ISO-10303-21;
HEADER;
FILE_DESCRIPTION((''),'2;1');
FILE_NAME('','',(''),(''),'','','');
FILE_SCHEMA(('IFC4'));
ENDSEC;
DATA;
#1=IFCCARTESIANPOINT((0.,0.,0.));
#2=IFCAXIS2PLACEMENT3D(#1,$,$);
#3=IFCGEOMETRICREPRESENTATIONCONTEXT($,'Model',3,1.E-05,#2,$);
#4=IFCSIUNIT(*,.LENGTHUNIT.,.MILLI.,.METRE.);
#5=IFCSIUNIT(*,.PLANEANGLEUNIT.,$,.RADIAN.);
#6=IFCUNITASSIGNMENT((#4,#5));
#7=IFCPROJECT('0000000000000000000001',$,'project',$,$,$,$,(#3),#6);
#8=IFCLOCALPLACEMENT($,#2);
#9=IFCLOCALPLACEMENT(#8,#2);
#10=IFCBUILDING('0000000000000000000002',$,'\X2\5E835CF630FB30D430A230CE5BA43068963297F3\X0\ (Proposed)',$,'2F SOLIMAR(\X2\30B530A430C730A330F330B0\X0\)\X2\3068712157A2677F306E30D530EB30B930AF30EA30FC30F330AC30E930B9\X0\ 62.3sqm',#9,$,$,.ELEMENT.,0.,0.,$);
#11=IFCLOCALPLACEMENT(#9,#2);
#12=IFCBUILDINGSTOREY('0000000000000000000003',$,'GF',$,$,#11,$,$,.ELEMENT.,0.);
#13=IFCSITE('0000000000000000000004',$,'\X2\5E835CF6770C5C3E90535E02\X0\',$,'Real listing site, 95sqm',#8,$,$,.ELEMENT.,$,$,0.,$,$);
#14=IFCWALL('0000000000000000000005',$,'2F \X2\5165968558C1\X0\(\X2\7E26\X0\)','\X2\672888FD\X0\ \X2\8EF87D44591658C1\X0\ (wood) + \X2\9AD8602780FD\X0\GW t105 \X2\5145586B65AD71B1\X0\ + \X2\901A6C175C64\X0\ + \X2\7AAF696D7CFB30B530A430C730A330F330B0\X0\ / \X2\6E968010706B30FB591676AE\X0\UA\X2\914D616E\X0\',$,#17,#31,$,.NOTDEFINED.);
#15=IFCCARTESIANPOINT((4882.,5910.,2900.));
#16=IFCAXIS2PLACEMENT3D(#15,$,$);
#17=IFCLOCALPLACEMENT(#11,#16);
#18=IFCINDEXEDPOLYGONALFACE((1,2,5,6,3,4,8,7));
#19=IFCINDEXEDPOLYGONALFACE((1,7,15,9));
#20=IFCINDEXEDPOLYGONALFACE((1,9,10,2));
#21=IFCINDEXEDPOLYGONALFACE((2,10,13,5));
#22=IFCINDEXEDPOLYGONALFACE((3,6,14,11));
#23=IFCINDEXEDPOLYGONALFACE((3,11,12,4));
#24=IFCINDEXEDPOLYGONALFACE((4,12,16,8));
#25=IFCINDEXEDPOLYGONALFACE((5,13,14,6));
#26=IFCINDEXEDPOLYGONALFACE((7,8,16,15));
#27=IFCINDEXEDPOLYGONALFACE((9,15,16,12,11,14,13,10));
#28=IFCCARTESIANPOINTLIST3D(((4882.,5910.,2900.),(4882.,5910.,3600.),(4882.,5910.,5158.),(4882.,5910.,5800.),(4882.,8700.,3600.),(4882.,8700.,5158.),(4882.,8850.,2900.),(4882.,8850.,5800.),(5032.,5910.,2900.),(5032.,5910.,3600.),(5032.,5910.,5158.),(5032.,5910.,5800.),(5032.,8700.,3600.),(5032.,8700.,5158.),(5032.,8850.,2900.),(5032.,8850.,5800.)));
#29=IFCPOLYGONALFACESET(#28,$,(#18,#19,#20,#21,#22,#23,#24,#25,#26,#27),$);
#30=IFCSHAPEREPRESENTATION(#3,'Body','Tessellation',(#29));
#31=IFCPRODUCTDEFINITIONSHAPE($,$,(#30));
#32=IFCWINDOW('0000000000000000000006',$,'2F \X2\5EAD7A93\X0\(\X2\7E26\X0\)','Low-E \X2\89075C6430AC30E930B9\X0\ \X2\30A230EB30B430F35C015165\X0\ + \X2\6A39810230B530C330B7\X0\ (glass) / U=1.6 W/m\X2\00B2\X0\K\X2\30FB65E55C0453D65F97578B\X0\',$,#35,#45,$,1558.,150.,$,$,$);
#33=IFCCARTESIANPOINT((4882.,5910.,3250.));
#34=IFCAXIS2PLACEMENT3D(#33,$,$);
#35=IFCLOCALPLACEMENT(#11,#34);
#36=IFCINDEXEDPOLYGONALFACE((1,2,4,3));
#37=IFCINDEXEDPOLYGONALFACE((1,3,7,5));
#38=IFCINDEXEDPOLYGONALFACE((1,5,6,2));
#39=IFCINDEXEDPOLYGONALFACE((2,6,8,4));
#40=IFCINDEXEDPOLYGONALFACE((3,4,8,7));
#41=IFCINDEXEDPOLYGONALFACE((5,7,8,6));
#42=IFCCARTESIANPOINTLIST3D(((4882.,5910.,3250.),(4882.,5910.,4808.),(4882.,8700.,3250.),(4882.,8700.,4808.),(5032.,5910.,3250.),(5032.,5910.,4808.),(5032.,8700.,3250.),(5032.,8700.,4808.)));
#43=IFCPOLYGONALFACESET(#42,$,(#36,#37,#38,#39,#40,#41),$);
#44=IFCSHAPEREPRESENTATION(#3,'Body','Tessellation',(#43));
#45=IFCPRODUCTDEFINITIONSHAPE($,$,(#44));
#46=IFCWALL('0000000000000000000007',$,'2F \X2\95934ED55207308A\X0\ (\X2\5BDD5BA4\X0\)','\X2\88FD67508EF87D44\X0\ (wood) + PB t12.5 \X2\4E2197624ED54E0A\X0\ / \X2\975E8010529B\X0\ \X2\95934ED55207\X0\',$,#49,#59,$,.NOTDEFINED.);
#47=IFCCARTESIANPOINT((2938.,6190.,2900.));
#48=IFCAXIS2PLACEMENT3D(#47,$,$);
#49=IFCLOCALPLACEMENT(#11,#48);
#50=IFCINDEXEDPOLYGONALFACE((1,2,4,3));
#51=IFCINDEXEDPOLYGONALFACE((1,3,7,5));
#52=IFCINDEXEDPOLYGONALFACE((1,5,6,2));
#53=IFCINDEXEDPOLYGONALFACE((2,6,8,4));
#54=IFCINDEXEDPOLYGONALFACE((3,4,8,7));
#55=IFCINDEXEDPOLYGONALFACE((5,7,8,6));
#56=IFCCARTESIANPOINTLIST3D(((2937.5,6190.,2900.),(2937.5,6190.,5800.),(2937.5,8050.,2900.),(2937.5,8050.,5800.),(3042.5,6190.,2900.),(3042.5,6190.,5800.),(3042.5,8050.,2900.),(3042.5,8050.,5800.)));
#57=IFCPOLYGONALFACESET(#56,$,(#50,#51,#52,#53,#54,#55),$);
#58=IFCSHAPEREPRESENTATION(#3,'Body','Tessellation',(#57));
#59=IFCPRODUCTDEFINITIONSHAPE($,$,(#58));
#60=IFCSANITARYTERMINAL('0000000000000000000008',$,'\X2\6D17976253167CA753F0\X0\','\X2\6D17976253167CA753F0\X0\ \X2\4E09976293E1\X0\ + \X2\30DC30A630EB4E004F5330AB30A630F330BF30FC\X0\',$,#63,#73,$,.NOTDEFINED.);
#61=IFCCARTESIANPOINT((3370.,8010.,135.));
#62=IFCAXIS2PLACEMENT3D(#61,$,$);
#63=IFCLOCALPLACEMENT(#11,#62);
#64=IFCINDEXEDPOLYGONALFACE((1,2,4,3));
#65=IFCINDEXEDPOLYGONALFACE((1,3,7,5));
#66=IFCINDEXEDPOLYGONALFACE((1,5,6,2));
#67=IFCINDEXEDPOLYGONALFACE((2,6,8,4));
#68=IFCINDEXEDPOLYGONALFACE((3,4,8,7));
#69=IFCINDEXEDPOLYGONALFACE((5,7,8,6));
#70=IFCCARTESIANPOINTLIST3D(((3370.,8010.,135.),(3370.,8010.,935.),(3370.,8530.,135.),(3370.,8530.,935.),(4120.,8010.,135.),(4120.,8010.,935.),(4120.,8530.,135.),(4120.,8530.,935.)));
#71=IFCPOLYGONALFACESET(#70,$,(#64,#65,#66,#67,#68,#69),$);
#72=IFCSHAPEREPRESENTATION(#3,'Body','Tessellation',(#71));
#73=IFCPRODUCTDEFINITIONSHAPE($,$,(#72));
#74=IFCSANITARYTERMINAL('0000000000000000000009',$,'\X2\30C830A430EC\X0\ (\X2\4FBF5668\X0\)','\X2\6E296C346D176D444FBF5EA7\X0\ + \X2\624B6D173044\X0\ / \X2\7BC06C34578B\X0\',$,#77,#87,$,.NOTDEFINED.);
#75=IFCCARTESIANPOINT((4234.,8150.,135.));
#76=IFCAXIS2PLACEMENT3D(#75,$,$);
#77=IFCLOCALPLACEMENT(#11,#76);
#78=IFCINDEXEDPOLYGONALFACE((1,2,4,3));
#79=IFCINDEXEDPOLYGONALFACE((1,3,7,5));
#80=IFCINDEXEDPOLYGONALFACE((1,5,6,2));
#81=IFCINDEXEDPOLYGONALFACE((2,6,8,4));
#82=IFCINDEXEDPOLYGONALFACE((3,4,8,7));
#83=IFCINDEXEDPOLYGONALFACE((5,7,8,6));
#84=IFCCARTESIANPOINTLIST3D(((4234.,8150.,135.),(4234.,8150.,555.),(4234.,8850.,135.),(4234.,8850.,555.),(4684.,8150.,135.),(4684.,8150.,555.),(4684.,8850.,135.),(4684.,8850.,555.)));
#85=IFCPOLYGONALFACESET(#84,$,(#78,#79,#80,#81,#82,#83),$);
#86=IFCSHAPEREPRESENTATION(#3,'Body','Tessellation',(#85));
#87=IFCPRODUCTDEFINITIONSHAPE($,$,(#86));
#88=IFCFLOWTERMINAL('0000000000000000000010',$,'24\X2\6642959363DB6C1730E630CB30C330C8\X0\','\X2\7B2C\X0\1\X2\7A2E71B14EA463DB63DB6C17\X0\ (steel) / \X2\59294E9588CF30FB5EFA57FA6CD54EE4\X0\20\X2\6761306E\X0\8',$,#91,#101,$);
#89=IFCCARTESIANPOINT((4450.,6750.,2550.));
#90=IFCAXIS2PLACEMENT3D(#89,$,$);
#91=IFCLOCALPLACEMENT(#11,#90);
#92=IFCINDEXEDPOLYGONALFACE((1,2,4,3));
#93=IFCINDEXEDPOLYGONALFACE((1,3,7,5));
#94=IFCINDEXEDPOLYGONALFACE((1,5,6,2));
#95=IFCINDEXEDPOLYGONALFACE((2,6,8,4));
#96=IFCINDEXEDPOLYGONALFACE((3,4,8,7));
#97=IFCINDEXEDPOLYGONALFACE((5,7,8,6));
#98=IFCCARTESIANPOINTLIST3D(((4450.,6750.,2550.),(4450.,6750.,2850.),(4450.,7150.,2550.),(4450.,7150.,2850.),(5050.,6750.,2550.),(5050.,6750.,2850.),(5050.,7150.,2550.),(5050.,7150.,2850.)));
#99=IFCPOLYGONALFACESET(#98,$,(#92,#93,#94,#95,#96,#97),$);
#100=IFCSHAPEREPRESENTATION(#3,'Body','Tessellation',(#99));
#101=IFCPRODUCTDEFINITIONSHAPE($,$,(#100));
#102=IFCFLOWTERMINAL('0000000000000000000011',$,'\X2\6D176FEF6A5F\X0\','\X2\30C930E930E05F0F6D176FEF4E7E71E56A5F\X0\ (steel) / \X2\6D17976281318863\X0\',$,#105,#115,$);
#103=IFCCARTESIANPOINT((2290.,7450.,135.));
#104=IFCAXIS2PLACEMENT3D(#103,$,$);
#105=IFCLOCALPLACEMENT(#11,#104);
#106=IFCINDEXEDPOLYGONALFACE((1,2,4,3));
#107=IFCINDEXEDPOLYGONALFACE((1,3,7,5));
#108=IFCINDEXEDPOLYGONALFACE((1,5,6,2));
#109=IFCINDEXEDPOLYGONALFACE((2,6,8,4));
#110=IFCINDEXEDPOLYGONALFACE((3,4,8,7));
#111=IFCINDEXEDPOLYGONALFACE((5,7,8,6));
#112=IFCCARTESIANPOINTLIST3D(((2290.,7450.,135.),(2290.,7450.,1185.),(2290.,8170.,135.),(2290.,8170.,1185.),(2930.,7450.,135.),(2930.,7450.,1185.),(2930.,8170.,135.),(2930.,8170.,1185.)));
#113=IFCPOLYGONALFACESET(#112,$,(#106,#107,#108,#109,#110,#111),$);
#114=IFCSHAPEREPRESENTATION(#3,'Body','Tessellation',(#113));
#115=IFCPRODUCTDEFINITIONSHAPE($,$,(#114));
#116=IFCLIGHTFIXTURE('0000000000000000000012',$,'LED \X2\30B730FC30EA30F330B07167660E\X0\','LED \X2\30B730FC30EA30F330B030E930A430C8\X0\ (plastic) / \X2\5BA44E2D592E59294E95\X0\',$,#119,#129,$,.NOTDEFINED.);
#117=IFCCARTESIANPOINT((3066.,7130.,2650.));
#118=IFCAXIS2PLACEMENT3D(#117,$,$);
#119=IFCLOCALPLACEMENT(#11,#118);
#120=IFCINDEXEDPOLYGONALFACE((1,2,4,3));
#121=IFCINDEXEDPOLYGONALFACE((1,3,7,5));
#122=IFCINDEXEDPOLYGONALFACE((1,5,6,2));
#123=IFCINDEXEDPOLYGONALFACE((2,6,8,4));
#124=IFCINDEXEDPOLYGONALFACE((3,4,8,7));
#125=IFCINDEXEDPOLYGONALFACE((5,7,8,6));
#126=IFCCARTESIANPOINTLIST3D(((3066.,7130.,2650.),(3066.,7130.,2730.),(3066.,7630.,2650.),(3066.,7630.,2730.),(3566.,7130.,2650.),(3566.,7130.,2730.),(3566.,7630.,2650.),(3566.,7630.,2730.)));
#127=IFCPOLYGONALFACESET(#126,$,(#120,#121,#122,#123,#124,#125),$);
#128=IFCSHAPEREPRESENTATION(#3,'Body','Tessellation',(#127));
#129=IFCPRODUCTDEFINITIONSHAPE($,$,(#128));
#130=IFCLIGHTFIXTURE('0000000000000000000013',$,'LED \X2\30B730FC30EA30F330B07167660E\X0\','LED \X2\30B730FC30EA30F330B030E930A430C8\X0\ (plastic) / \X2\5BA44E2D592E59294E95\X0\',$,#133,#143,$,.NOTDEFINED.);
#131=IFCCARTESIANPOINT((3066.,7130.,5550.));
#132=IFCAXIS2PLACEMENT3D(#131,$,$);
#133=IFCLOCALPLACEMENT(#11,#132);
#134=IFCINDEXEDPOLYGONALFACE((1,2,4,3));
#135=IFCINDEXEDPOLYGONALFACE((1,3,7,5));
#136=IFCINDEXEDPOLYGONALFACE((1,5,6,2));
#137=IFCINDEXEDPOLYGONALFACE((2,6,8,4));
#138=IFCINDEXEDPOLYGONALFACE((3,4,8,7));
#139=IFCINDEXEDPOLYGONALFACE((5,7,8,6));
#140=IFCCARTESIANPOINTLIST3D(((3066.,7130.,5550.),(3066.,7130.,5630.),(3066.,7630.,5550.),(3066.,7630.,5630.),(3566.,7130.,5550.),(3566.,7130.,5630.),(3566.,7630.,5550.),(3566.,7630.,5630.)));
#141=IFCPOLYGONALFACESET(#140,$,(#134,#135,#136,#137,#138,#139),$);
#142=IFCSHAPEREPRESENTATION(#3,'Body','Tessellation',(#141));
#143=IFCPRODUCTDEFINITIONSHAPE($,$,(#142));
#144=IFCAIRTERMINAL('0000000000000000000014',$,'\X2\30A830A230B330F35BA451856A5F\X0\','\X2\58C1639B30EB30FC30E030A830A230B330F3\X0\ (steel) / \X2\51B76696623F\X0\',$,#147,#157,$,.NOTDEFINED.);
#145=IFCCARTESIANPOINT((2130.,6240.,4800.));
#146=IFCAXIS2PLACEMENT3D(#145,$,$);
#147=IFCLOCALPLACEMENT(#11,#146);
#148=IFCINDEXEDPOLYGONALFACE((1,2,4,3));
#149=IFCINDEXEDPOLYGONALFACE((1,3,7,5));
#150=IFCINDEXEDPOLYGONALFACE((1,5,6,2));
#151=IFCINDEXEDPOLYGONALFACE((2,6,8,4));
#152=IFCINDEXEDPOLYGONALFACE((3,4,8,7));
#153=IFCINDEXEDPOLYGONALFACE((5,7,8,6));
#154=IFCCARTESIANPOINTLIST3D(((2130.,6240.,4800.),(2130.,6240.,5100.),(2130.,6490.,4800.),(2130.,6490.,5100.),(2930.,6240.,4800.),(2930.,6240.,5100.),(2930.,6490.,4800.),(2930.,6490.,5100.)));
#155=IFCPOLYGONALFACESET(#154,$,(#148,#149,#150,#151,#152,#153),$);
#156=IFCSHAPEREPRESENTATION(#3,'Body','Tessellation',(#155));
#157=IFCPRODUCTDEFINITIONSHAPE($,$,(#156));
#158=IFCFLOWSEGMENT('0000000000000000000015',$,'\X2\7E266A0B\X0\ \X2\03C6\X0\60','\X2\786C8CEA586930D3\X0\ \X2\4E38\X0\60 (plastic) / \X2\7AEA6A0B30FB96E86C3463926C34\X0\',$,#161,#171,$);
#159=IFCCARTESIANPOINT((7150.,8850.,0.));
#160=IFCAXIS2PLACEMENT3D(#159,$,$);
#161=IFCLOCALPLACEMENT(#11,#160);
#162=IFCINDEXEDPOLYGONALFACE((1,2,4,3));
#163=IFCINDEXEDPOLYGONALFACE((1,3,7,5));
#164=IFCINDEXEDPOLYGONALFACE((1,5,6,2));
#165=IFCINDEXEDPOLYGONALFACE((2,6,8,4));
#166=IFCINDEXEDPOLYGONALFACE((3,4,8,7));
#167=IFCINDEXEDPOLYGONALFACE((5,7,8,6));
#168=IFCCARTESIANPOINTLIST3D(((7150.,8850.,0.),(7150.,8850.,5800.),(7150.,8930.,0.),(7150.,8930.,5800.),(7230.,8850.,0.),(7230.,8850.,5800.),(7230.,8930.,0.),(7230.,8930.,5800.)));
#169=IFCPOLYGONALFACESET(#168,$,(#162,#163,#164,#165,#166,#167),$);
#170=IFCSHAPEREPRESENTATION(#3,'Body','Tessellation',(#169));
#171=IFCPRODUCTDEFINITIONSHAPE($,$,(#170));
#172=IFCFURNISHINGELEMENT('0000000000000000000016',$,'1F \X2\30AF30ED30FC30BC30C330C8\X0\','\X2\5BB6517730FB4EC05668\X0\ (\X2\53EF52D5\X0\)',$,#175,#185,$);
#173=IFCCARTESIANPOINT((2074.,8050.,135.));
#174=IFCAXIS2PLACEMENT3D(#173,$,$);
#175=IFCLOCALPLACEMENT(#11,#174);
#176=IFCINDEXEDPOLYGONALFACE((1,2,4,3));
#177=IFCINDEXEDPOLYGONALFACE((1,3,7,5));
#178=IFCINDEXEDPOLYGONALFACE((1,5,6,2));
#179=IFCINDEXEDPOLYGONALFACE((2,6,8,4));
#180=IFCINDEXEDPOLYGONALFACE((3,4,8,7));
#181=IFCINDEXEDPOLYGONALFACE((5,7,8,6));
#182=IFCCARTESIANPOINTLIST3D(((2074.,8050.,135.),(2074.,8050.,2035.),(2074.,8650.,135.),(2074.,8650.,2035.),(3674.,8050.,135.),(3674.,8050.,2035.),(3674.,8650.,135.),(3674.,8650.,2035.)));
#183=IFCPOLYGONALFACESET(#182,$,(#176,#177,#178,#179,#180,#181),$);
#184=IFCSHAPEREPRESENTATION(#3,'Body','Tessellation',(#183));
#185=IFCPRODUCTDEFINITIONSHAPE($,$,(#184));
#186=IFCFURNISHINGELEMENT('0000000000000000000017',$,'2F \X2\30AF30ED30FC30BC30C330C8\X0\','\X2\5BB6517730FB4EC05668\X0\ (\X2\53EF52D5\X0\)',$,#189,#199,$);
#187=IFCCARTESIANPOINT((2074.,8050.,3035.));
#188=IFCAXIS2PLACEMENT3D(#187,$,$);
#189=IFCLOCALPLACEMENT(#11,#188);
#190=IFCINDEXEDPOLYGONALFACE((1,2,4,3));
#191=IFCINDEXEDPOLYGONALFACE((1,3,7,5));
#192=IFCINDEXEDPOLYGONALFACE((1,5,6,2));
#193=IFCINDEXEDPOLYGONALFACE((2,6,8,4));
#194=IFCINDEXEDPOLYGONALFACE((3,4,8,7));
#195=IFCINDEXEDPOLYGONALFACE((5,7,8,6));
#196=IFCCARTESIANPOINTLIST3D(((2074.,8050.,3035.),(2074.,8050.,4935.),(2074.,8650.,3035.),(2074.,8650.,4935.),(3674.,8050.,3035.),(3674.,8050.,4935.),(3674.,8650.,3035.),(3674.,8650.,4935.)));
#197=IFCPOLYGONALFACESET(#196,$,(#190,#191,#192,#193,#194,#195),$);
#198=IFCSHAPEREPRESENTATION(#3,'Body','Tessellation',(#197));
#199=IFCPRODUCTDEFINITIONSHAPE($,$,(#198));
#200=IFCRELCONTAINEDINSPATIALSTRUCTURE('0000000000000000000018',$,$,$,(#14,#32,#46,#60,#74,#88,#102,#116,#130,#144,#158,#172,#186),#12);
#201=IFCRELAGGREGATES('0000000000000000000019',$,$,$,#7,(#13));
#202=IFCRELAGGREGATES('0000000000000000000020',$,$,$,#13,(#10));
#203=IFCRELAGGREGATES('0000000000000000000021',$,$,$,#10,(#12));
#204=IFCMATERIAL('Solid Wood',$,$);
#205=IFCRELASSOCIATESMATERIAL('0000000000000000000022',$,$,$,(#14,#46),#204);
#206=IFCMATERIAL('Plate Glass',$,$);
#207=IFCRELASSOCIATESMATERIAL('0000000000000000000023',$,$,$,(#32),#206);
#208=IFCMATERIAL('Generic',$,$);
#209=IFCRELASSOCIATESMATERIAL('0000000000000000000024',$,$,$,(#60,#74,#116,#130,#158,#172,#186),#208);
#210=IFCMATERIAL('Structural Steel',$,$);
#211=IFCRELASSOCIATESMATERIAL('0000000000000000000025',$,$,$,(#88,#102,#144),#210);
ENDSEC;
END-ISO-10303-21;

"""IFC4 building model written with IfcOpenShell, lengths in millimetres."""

from ifc_helpers import new_model, si_unit, frame, frame_2d, origin, place, context, project, spatial, rectangle, extrude, material, element, fill, save


model = new_model("IFC4")

# Units and contexts
model_context = context("Model", 3, precision=1e-05, world=origin())
ifc_project = project(units=[si_unit("LENGTHUNIT", "METRE", prefix="MILLI"), si_unit("PLANEANGLEUNIT", "RADIAN")], contexts=[model_context])

# Site, building, storey
site_placement = place(None, origin())
site = spatial("IfcSite", under=ifc_project, at=site_placement, Name="広島県尾道市", ObjectType="Real listing site, 95sqm", CompositionType="ELEMENT", RefElevation=0.0)
building_placement = place(site_placement, origin())
building = spatial("IfcBuilding", under=site, at=building_placement, Name="広島・ピアノ室と防音 (Proposed)", ObjectType="2F SOLIMAR(サイディング)と無垢板のフルスクリーンガラス 62.3sqm", CompositionType="ELEMENT", ElevationOfRefHeight=0.0, ElevationOfTerrain=0.0)
storey_placement = place(building_placement, origin())
storey = spatial("IfcBuildingStorey", under=building, at=storey_placement, Name="GF", CompositionType="ELEMENT", Elevation=0.0)

# Shared definitions
ifc_material_1 = material(Name="Solid Wood")

# Shared definitions
ifc_material_2 = material(Name="Plate Glass")

# Wall, opening, window
wall_1_placement = place(storey_placement, frame((4882.0, 5910.0, 2900.0)))
wall_1 = element("IfcWall", 1, at=wall_1_placement, inside=storey, material=ifc_material_1, Name="2F 入隅壁(縦)", Description="木製 軸組外壁 (wood) + 高性能GW t105 充填断熱 + 通気層 + 窯業系サイディング / 準耐火・外皮UA配慮", PredefinedType="NOTDEFINED", context=model_context, shape_type="SweptSolid", body=[
    extrude(rectangle(XDim=150.0, YDim=2940.0, at=frame_2d((75.0, 1470.0))), frame((4882.0, 5910.0, 2900.0)), (0.0, 0.0, 1.0), 2900.0),
])
opening_1_placement = place(storey_placement, frame((4882.0, 5910.0, 3250.0)))
opening_1 = element("IfcOpeningElement", 2, at=opening_1_placement, cuts=wall_1, PredefinedType="NOTDEFINED", context=model_context, shape_type="SweptSolid", body=[
    extrude(rectangle(XDim=150.0, YDim=2790.0, at=frame_2d((75.0, 1395.0))), frame((4882.0, 5910.0, 3250.0)), (0.0, 0.0, 1.0), 1558.0),
])
window_1_placement = place(storey_placement, frame((4882.0, 5910.0, 3250.0)))
window_1 = element("IfcWindow", 3, at=window_1_placement, inside=storey, material=ifc_material_2, Name="2F 庭窓(縦)", Description="Low-E 複層ガラス アルゴン封入 + 樹脂サッシ (glass) / U=1.6 W/m²K・日射取得型", OverallHeight=1558.0, OverallWidth=150.0, context=model_context, shape_type="SweptSolid", body=[
    extrude(rectangle(XDim=150.0, YDim=2790.0, at=frame_2d((75.0, 1395.0))), frame((4882.0, 5910.0, 3250.0)), (0.0, 0.0, 1.0), 1558.0),
])
fill(opening_1, window_1)

# Wall
wall_2_placement = place(storey_placement, frame((2938.0, 6190.0, 2900.0)))
element("IfcWall", 4, at=wall_2_placement, inside=storey, material=ifc_material_1, Name="2F 間仕切り (寝室)", Description="製材軸組 (wood) + PB t12.5 両面仕上 / 非耐力 間仕切", PredefinedType="NOTDEFINED", context=model_context, shape_type="SweptSolid", body=[
    extrude(rectangle(XDim=105.0, YDim=1860.0, at=frame_2d((52.0, 930.0))), frame((2938.0, 6190.0, 2900.0)), (0.0, 0.0, 1.0), 2900.0),
])

# Sanitary terminals
ifc_material_3 = material(Name="Generic")
sanitary_terminal_1_placement = place(storey_placement, frame((3370.0, 8010.0, 135.0)))
element("IfcSanitaryTerminal", 5, at=sanitary_terminal_1_placement, inside=storey, material=ifc_material_3, Name="洗面化粧台", Description="洗面化粧台 三面鏡 + ボウル一体カウンター", PredefinedType="NOTDEFINED", context=model_context, shape_type="SweptSolid", body=[
    extrude(rectangle(XDim=750.0, YDim=520.0, at=frame_2d((375.0, 260.0))), frame((3370.0, 8010.0, 135.0)), (0.0, 0.0, 1.0), 800.0),
])
sanitary_terminal_2_placement = place(storey_placement, frame((4234.0, 8150.0, 135.0)))
element("IfcSanitaryTerminal", 6, at=sanitary_terminal_2_placement, inside=storey, material=ifc_material_3, Name="トイレ (便器)", Description="温水洗浄便座 + 手洗い / 節水型", PredefinedType="NOTDEFINED", context=model_context, shape_type="SweptSolid", body=[
    extrude(rectangle(XDim=450.0, YDim=700.0, at=frame_2d((225.0, 350.0))), frame((4234.0, 8150.0, 135.0)), (0.0, 0.0, 1.0), 420.0),
])

# Flow terminals
ifc_material_4 = material(Name="Structural Steel")
flow_terminal_1_placement = place(storey_placement, frame((4450.0, 6750.0, 2550.0)))
element("IfcFlowTerminal", 7, at=flow_terminal_1_placement, inside=storey, material=ifc_material_4, Name="24時間換気ユニット", Description="第1種熱交換換気 (steel) / 天井裏・建基法令20条の8", context=model_context, shape_type="SweptSolid", body=[
    extrude(rectangle(XDim=600.0, YDim=400.0, at=frame_2d((300.0, 200.0))), frame((4450.0, 6750.0, 2550.0)), (0.0, 0.0, 1.0), 300.0),
])
flow_terminal_2_placement = place(storey_placement, frame((2290.0, 7450.0, 135.0)))
element("IfcFlowTerminal", 8, at=flow_terminal_2_placement, inside=storey, material=ifc_material_4, Name="洗濯機", Description="ドラム式洗濯乾燥機 (steel) / 洗面脱衣", context=model_context, shape_type="SweptSolid", body=[
    extrude(rectangle(XDim=640.0, YDim=720.0, at=frame_2d((320.0, 360.0))), frame((2290.0, 7450.0, 135.0)), (0.0, 0.0, 1.0), 1050.0),
])

# Light fixtures
light_fixture_1_placement = place(storey_placement, frame((3066.0, 7130.0, 2650.0)))
element("IfcLightFixture", 9, at=light_fixture_1_placement, inside=storey, material=ifc_material_3, Name="LED シーリング照明", Description="LED シーリングライト (plastic) / 室中央天井", PredefinedType="NOTDEFINED", context=model_context, shape_type="SweptSolid", body=[
    extrude(rectangle(XDim=500.0, YDim=500.0, at=frame_2d((250.0, 250.0))), frame((3066.0, 7130.0, 2650.0)), (0.0, 0.0, 1.0), 80.0),
])
light_fixture_2_placement = place(storey_placement, frame((3066.0, 7130.0, 5550.0)))
element("IfcLightFixture", 10, at=light_fixture_2_placement, inside=storey, material=ifc_material_3, Name="LED シーリング照明", Description="LED シーリングライト (plastic) / 室中央天井", PredefinedType="NOTDEFINED", context=model_context, shape_type="SweptSolid", body=[
    extrude(rectangle(XDim=500.0, YDim=500.0, at=frame_2d((250.0, 250.0))), frame((3066.0, 7130.0, 5550.0)), (0.0, 0.0, 1.0), 80.0),
])

# Air terminal
air_terminal_placement = place(storey_placement, frame((2130.0, 6240.0, 4800.0)))
element("IfcAirTerminal", 11, at=air_terminal_placement, inside=storey, material=ifc_material_4, Name="エアコン室内機", Description="壁掛ルームエアコン (steel) / 冷暖房", PredefinedType="NOTDEFINED", context=model_context, shape_type="SweptSolid", body=[
    extrude(rectangle(XDim=800.0, YDim=250.0, at=frame_2d((400.0, 125.0))), frame((2130.0, 6240.0, 4800.0)), (0.0, 0.0, 1.0), 300.0),
])

# Flow segment
flow_segment_placement = place(storey_placement, frame((7150.0, 8850.0, 0.0)))
element("IfcFlowSegment", 12, at=flow_segment_placement, inside=storey, material=ifc_material_3, Name="縦樋 φ60", Description="硬質塩ビ 丸60 (plastic) / 竪樋・雨水排水", context=model_context, shape_type="SweptSolid", body=[
    extrude(rectangle(XDim=80.0, YDim=80.0, at=frame_2d((40.0, 40.0))), frame((7150.0, 8850.0, 0.0)), (0.0, 0.0, 1.0), 5800.0),
])

# Furnishing elements
furnishing_1_placement = place(storey_placement, frame((2074.0, 8050.0, 135.0)))
element("IfcFurnishingElement", 13, at=furnishing_1_placement, inside=storey, material=ifc_material_3, Name="1F クローゼット", Description="家具・什器 (可動)", context=model_context, shape_type="SweptSolid", body=[
    extrude(rectangle(XDim=1600.0, YDim=600.0, at=frame_2d((800.0, 300.0))), frame((2074.0, 8050.0, 135.0)), (0.0, 0.0, 1.0), 1900.0),
])
furnishing_2_placement = place(storey_placement, frame((2074.0, 8050.0, 3035.0)))
element("IfcFurnishingElement", 14, at=furnishing_2_placement, inside=storey, material=ifc_material_3, Name="2F クローゼット", Description="家具・什器 (可動)", context=model_context, shape_type="SweptSolid", body=[
    extrude(rectangle(XDim=1600.0, YDim=600.0, at=frame_2d((800.0, 300.0))), frame((2074.0, 8050.0, 3035.0)), (0.0, 0.0, 1.0), 1900.0),
])

save(model, "model.ifc")
